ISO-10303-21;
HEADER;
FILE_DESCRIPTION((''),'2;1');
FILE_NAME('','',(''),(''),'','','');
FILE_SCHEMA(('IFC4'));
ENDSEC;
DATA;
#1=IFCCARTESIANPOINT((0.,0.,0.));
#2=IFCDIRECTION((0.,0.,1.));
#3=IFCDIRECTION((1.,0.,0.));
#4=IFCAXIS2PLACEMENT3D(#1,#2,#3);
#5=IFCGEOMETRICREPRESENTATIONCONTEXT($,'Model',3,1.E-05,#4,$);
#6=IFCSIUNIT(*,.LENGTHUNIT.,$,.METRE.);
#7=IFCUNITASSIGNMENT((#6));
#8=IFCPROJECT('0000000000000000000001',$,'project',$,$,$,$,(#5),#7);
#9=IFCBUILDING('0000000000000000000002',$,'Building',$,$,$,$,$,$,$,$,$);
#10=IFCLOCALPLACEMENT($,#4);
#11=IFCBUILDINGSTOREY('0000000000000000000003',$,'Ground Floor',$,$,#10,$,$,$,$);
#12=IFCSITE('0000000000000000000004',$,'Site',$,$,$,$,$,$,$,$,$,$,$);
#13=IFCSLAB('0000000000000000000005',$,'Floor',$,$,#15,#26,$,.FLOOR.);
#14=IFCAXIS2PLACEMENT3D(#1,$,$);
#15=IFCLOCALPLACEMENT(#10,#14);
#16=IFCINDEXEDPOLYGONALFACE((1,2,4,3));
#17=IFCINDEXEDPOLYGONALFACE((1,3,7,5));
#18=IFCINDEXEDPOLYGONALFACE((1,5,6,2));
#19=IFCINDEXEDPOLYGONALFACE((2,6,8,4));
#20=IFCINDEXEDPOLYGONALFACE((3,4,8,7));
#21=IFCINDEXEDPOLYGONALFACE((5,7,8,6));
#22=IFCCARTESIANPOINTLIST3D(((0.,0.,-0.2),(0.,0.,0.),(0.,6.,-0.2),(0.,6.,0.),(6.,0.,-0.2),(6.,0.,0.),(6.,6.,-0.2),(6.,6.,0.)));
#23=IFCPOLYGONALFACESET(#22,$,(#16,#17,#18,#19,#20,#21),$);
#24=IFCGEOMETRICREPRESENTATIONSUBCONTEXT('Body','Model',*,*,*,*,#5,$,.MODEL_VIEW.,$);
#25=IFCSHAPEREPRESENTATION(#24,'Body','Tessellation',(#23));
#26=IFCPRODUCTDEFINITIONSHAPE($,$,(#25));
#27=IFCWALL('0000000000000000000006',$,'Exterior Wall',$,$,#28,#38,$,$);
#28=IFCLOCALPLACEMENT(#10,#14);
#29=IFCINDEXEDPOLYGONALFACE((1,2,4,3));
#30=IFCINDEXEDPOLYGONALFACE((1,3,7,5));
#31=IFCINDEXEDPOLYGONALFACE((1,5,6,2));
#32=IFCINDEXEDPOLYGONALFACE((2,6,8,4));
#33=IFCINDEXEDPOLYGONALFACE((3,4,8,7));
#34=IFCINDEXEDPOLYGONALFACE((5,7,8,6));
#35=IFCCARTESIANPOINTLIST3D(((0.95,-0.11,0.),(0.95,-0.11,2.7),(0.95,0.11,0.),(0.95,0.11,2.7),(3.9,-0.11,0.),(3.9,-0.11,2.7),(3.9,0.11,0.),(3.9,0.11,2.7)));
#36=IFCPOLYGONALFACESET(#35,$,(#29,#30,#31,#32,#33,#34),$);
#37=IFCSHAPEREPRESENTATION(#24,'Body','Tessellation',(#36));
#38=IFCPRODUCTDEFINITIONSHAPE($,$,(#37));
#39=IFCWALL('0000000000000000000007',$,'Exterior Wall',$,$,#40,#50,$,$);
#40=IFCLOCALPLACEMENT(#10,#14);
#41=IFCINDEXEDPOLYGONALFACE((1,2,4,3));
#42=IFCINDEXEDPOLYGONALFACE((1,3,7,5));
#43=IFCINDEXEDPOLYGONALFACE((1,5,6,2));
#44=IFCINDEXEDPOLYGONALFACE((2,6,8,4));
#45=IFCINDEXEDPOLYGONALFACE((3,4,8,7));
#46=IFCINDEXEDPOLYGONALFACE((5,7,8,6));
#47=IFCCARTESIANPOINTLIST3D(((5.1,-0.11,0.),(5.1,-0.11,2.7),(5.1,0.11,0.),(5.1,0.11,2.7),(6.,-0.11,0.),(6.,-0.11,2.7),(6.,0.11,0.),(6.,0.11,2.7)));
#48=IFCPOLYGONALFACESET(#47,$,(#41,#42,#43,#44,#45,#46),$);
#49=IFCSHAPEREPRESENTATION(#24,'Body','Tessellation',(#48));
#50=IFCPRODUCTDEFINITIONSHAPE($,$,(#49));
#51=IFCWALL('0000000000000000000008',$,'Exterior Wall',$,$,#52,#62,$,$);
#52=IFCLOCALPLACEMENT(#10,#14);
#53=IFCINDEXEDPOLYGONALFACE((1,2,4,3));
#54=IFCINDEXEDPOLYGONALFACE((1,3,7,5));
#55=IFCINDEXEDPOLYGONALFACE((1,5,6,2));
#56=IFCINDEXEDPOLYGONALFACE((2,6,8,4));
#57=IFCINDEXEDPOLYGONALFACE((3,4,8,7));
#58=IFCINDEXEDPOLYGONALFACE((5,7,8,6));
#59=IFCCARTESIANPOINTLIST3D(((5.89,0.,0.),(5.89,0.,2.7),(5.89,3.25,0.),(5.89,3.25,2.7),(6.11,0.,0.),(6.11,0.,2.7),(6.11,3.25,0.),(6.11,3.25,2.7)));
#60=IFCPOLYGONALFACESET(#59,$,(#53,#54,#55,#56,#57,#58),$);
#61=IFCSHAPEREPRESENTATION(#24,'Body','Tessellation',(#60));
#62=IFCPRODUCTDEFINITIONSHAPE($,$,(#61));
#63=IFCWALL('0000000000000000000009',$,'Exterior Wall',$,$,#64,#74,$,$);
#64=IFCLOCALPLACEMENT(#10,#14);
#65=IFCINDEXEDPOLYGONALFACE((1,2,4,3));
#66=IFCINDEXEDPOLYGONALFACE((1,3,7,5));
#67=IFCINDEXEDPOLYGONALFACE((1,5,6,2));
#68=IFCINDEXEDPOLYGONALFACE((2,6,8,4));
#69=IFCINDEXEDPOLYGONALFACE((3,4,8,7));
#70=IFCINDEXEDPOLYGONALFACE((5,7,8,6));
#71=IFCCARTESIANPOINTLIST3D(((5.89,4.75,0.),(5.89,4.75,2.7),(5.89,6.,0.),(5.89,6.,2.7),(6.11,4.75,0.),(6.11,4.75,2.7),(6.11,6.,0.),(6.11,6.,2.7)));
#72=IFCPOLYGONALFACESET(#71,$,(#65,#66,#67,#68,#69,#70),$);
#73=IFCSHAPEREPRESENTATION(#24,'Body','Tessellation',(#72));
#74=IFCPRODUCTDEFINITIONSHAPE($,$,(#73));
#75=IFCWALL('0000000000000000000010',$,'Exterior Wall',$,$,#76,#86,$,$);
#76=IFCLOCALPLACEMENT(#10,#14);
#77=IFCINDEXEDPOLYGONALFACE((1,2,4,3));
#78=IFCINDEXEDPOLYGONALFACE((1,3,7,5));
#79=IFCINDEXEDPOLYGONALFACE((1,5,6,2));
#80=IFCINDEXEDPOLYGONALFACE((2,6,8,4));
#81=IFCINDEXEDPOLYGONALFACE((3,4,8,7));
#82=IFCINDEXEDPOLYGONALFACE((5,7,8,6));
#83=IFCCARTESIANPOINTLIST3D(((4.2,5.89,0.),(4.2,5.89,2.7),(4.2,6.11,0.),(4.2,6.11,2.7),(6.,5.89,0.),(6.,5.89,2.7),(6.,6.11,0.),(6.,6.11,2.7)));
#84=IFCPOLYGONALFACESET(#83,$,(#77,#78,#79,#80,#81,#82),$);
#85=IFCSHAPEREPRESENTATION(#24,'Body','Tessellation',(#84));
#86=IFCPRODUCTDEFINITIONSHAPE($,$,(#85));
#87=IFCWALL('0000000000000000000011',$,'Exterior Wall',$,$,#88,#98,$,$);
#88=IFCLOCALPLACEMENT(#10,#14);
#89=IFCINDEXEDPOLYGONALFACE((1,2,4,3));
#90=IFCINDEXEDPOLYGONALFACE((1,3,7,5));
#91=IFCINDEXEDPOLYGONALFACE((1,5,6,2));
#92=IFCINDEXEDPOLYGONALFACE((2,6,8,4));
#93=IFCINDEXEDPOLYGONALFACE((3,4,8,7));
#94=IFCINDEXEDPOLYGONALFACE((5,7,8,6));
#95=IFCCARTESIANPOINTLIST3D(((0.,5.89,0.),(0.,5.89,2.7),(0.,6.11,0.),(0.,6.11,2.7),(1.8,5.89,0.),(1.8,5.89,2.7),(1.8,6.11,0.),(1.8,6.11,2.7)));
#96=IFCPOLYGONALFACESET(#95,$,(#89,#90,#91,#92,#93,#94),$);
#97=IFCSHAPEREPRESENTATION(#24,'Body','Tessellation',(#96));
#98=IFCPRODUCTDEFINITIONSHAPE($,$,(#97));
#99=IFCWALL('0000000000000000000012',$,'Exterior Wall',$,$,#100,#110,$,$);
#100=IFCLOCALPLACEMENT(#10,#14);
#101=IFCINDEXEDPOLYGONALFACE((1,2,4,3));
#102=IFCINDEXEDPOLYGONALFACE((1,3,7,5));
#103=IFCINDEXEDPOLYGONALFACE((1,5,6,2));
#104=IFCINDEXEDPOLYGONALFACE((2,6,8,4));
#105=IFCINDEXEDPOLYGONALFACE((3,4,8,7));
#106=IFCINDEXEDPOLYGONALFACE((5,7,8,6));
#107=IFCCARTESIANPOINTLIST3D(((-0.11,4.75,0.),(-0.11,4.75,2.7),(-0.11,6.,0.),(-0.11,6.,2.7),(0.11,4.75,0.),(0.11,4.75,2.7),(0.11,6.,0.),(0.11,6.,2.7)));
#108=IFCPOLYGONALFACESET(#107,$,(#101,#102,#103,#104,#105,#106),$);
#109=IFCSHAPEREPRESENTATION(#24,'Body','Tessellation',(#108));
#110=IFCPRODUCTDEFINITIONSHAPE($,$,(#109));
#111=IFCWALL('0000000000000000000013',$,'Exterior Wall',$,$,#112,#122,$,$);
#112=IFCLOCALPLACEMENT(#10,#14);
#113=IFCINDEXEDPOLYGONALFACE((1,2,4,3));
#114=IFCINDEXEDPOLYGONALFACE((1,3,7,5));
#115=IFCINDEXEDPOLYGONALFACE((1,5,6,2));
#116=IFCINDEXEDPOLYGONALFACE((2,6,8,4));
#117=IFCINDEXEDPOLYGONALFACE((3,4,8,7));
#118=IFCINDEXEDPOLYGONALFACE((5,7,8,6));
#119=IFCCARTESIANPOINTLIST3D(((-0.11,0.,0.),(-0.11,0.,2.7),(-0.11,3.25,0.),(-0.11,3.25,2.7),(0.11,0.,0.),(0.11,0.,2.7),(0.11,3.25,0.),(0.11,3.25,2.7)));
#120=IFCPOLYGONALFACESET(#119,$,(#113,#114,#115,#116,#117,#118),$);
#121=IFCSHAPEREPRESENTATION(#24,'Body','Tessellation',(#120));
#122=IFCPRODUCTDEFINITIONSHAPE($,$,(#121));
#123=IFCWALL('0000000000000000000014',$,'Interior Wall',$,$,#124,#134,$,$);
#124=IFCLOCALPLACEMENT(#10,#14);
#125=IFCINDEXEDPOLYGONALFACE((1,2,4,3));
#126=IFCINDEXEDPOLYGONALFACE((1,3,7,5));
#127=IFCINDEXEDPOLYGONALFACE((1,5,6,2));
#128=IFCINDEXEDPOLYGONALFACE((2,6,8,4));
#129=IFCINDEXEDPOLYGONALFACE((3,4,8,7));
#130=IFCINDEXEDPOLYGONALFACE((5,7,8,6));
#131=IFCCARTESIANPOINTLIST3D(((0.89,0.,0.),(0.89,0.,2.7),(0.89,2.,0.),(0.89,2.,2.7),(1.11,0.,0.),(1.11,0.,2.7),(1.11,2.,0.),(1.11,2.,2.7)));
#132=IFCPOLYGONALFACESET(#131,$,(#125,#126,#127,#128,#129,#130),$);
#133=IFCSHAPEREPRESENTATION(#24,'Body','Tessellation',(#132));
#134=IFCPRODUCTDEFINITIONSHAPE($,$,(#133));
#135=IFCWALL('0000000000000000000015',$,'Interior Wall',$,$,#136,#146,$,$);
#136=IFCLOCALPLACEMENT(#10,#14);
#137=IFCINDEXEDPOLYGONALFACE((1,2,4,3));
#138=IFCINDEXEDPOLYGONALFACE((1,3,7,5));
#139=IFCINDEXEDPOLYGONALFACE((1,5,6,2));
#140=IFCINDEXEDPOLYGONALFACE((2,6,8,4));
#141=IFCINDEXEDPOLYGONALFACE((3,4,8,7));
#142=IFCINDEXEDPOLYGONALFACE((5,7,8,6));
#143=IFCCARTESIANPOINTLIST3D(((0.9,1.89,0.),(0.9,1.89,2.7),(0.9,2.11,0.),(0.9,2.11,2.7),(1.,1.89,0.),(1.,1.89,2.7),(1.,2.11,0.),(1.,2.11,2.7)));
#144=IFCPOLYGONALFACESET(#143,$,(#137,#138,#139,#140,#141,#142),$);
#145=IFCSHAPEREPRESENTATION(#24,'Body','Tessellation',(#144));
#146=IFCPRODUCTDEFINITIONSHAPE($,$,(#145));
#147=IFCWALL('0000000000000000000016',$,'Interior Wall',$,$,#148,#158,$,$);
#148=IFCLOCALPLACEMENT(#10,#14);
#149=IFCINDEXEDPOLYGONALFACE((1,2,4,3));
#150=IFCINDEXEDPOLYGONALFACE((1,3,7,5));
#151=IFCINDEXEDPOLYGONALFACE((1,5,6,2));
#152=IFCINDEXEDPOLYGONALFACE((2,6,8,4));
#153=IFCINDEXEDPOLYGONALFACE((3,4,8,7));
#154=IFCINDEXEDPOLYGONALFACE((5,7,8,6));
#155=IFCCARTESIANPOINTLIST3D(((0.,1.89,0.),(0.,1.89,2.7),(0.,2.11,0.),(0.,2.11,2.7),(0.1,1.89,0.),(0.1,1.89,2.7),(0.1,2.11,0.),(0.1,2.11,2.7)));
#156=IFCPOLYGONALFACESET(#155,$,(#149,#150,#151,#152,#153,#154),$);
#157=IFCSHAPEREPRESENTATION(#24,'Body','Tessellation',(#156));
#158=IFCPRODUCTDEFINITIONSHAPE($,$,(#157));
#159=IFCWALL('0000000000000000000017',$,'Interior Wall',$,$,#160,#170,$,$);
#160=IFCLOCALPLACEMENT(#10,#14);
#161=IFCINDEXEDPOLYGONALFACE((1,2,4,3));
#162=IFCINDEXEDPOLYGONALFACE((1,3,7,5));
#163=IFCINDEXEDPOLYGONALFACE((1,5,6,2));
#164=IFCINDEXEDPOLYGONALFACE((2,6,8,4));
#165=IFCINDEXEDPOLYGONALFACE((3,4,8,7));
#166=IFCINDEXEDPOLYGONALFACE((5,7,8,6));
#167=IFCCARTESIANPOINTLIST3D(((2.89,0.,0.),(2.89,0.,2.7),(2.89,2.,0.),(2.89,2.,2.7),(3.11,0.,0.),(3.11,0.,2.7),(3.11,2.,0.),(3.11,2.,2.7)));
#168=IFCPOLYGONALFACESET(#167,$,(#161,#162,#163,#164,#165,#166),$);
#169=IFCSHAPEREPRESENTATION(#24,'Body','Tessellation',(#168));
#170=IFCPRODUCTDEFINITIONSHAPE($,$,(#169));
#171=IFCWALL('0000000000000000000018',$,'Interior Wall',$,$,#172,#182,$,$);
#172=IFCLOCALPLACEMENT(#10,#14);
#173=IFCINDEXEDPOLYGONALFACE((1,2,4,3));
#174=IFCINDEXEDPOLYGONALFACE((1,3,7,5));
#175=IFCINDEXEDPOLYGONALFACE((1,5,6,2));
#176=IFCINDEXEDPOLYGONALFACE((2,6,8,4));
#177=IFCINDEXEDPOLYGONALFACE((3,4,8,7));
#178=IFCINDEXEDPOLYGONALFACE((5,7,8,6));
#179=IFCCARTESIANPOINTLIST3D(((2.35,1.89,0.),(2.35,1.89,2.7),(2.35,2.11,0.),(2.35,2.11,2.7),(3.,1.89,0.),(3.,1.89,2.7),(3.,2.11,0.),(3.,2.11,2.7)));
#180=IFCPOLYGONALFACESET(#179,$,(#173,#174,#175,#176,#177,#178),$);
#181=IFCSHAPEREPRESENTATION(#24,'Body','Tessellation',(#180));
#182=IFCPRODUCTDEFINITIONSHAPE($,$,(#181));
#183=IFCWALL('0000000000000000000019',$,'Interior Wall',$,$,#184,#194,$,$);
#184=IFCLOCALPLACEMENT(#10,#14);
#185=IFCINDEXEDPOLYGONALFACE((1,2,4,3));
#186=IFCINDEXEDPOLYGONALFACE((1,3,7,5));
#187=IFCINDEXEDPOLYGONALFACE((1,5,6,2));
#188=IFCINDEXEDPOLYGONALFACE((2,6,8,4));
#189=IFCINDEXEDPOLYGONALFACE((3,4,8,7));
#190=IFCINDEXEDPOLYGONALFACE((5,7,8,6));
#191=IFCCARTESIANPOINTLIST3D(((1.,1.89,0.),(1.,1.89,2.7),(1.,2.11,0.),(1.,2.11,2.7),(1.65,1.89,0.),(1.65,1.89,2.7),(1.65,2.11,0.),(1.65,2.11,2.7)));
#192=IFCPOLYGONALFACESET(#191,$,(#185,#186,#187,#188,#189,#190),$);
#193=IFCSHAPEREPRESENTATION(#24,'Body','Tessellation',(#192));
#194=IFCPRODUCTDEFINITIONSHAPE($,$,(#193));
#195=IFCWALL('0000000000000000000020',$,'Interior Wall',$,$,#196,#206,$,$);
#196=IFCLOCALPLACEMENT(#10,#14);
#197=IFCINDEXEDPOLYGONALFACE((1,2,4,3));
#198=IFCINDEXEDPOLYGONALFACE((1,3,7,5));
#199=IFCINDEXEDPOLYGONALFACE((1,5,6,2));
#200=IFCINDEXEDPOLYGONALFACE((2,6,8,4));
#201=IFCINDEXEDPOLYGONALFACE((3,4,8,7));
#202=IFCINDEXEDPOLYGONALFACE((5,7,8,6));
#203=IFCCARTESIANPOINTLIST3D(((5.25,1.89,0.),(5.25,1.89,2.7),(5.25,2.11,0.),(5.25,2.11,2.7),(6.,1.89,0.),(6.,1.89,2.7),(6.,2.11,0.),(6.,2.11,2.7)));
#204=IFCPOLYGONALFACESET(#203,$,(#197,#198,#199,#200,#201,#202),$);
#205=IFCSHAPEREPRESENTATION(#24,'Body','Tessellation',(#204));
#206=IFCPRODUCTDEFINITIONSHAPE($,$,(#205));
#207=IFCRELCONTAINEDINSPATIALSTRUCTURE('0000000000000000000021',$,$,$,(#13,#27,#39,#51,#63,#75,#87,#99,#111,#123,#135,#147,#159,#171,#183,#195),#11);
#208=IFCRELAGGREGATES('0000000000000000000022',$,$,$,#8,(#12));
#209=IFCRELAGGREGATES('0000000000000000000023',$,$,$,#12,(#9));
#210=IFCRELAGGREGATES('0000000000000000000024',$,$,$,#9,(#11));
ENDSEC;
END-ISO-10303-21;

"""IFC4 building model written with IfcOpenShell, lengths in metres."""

from ifc_helpers import new_model, si_unit, frame, origin_with_axes, place, context, subcontext, project, spatial, indexed_curve, outline, extrude, element, save


model = new_model("IFC4")

# Units and contexts
model_context = context("Model", 3, precision=1e-05, world=origin_with_axes())
body_context = subcontext(model_context, "Body", "Model", "MODEL_VIEW")
ifc_project = project(units=[si_unit("LENGTHUNIT", "METRE")], contexts=[model_context])

# Site, building, storey
site = spatial("IfcSite", under=ifc_project, Name="Site")
building = spatial("IfcBuilding", under=site, Name="Building")
storey_placement = place(None, origin_with_axes())
storey = spatial("IfcBuildingStorey", under=building, at=storey_placement, Name="Ground Floor")

# Slab
slab_placement = place(storey_placement, frame((0.0, 0.0, -0.2), z_axis=(0.0, 0.0, 1.0), x_axis=(1.0, 0.0, 0.0)))
element("IfcSlab", 1, at=slab_placement, inside=storey, Name="Floor", PredefinedType="FLOOR", context=body_context, shape_type="SweptSolid", body=[
    extrude(outline(indexed_curve([(0.0, 0.0), (6.0, 0.0), (6.0, 6.0), (0.0, 6.0)])), None, (0.0, 0.0, 1.0), 0.2),
])

# Walls
wall_1_placement = place(storey_placement, frame((0.95, 0.0, 0.0), z_axis=(0.0, 0.0, 1.0), x_axis=(1.0, 0.0, 0.0)))
element("IfcWall", 2, at=wall_1_placement, inside=storey, Name="Exterior Wall", context=body_context, shape_type="SweptSolid", body=[
    extrude(outline(indexed_curve([(0.0, 0.0), (0.0, 0.22), (2.95, 0.22), (2.95, 0.0), (0.0, 0.0)], self_intersect=False)), frame((0.0, -0.11, 0.0), z_axis=(0.0, 0.0, 1.0), x_axis=(1.0, 0.0, 0.0)), (0.0, 0.0, 1.0), 2.7),
])
wall_2_placement = place(storey_placement, frame((5.1, 0.0, 0.0), z_axis=(0.0, 0.0, 1.0), x_axis=(1.0, 0.0, 0.0)))
element("IfcWall", 3, at=wall_2_placement, inside=storey, Name="Exterior Wall", context=body_context, shape_type="SweptSolid", body=[
    extrude(outline(indexed_curve([(0.0, 0.0), (0.0, 0.22), (0.9, 0.22), (0.9, 0.0), (0.0, 0.0)], self_intersect=False)), frame((0.0, -0.11, 0.0), z_axis=(0.0, 0.0, 1.0), x_axis=(1.0, 0.0, 0.0)), (0.0, 0.0, 1.0), 2.7),
])
wall_3_placement = place(storey_placement, frame((6.0, 0.0, 0.0), z_axis=(0.0, 0.0, 1.0), x_axis=(0.0, 1.0, 0.0)))
element("IfcWall", 4, at=wall_3_placement, inside=storey, Name="Exterior Wall", context=body_context, shape_type="SweptSolid", body=[
    extrude(outline(indexed_curve([(0.0, 0.0), (0.0, 0.22), (3.25, 0.22), (3.25, 0.0), (0.0, 0.0)], self_intersect=False)), frame((0.0, -0.11, 0.0), z_axis=(0.0, 0.0, 1.0), x_axis=(1.0, 0.0, 0.0)), (0.0, 0.0, 1.0), 2.7),
])
wall_4_placement = place(storey_placement, frame((6.0, 4.75, 0.0), z_axis=(0.0, 0.0, 1.0), x_axis=(0.0, 1.0, 0.0)))
element("IfcWall", 5, at=wall_4_placement, inside=storey, Name="Exterior Wall", context=body_context, shape_type="SweptSolid", body=[
    extrude(outline(indexed_curve([(0.0, 0.0), (0.0, 0.22), (1.25, 0.22), (1.25, 0.0), (0.0, 0.0)], self_intersect=False)), frame((0.0, -0.11, 0.0), z_axis=(0.0, 0.0, 1.0), x_axis=(1.0, 0.0, 0.0)), (0.0, 0.0, 1.0), 2.7),
])
for number, where, z_axis, x_axis, name in (
    (6, (6.0, 6.0, 0.0), (0.0, 0.0, 1.0), (-1.0, 0.0, 0.0), "Exterior Wall"),
    (7, (1.8, 6.0, 0.0), (0.0, 0.0, 1.0), (-1.0, 0.0, 0.0), "Exterior Wall"),
):
    element("IfcWall", number, at=place(storey_placement, frame(where, z_axis=z_axis, x_axis=x_axis)), inside=storey, Name=name, context=body_context, shape_type="SweptSolid", body=[
        extrude(outline(indexed_curve([(0.0, 0.0), (0.0, 0.22), (1.8, 0.22), (1.8, 0.0), (0.0, 0.0)], self_intersect=False)), frame((0.0, -0.11, 0.0), z_axis=(0.0, 0.0, 1.0), x_axis=(1.0, 0.0, 0.0)), (0.0, 0.0, 1.0), 2.7),
    ])
wall_5_placement = place(storey_placement, frame((0.0, 6.0, 0.0), z_axis=(0.0, 0.0, 1.0), x_axis=(0.0, -1.0, 0.0)))
element("IfcWall", 8, at=wall_5_placement, inside=storey, Name="Exterior Wall", context=body_context, shape_type="SweptSolid", body=[
    extrude(outline(indexed_curve([(0.0, 0.0), (0.0, 0.22), (1.25, 0.22), (1.25, 0.0), (0.0, 0.0)], self_intersect=False)), frame((0.0, -0.11, 0.0), z_axis=(0.0, 0.0, 1.0), x_axis=(1.0, 0.0, 0.0)), (0.0, 0.0, 1.0), 2.7),
])
wall_6_placement = place(storey_placement, frame((0.0, 3.25, 0.0), z_axis=(0.0, 0.0, 1.0), x_axis=(0.0, -1.0, 0.0)))
element("IfcWall", 9, at=wall_6_placement, inside=storey, Name="Exterior Wall", context=body_context, shape_type="SweptSolid", body=[
    extrude(outline(indexed_curve([(0.0, 0.0), (0.0, 0.22), (3.25, 0.22), (3.25, 0.0), (0.0, 0.0)], self_intersect=False)), frame((0.0, -0.11, 0.0), z_axis=(0.0, 0.0, 1.0), x_axis=(1.0, 0.0, 0.0)), (0.0, 0.0, 1.0), 2.7),
])
wall_7_placement = place(storey_placement, frame((1.0, 0.0, 0.0), z_axis=(0.0, 0.0, 1.0), x_axis=(0.0, 1.0, 0.0)))
element("IfcWall", 10, at=wall_7_placement, inside=storey, Name="Interior Wall", context=body_context, shape_type="SweptSolid", body=[
    extrude(outline(indexed_curve([(0.0, 0.0), (0.0, 0.22), (2.0, 0.22), (2.0, 0.0), (0.0, 0.0)], self_intersect=False)), frame((0.0, -0.11, 0.0), z_axis=(0.0, 0.0, 1.0), x_axis=(1.0, 0.0, 0.0)), (0.0, 0.0, 1.0), 2.7),
])
for number, where, z_axis, x_axis, name in (
    (11, (1.0, 2.0, 0.0), (0.0, 0.0, 1.0), (-1.0, 0.0, 0.0), "Interior Wall"),
    (12, (0.1, 2.0, 0.0), (0.0, 0.0, 1.0), (-1.0, 0.0, 0.0), "Interior Wall"),
):
    element("IfcWall", number, at=place(storey_placement, frame(where, z_axis=z_axis, x_axis=x_axis)), inside=storey, Name=name, context=body_context, shape_type="SweptSolid", body=[
        extrude(outline(indexed_curve([(0.0, 0.0), (0.0, 0.22), (0.1, 0.22), (0.1, 0.0), (0.0, 0.0)], self_intersect=False)), frame((0.0, -0.11, 0.0), z_axis=(0.0, 0.0, 1.0), x_axis=(1.0, 0.0, 0.0)), (0.0, 0.0, 1.0), 2.7),
    ])
wall_8_placement = place(storey_placement, frame((3.0, 0.0, 0.0), z_axis=(0.0, 0.0, 1.0), x_axis=(0.0, 1.0, 0.0)))
element("IfcWall", 13, at=wall_8_placement, inside=storey, Name="Interior Wall", context=body_context, shape_type="SweptSolid", body=[
    extrude(outline(indexed_curve([(0.0, 0.0), (0.0, 0.22), (2.0, 0.22), (2.0, 0.0), (0.0, 0.0)], self_intersect=False)), frame((0.0, -0.11, 0.0), z_axis=(0.0, 0.0, 1.0), x_axis=(1.0, 0.0, 0.0)), (0.0, 0.0, 1.0), 2.7),
])
for number, where, z_axis, x_axis, name in (
    (14, (3.0, 2.0, 0.0), (0.0, 0.0, 1.0), (-1.0, 0.0, 0.0), "Interior Wall"),
    (15, (1.65, 2.0, 0.0), (0.0, 0.0, 1.0), (-1.0, 0.0, 0.0), "Interior Wall"),
):
    element("IfcWall", number, at=place(storey_placement, frame(where, z_axis=z_axis, x_axis=x_axis)), inside=storey, Name=name, context=body_context, shape_type="SweptSolid", body=[
        extrude(outline(indexed_curve([(0.0, 0.0), (0.0, 0.22), (0.65, 0.22), (0.65, 0.0), (0.0, 0.0)], self_intersect=False)), frame((0.0, -0.11, 0.0), z_axis=(0.0, 0.0, 1.0), x_axis=(1.0, 0.0, 0.0)), (0.0, 0.0, 1.0), 2.7),
    ])
for number, where, z_axis, x_axis, name in (
    (16, (6.0, 2.0, 0.0), (0.0, 0.0, 1.0), (-1.0, 0.0, 0.0), "Interior Wall"),
):
    element("IfcWall", number, at=place(storey_placement, frame(where, z_axis=z_axis, x_axis=x_axis)), inside=storey, Name=name, context=body_context, shape_type="SweptSolid", body=[
        extrude(outline(indexed_curve([(0.0, 0.0), (0.0, 0.22), (0.75, 0.22), (0.75, 0.0), (0.0, 0.0)], self_intersect=False)), frame((0.0, -0.11, 0.0), z_axis=(0.0, 0.0, 1.0), x_axis=(1.0, 0.0, 0.0)), (0.0, 0.0, 1.0), 2.7),
    ])

save(model, "model.ifc")
